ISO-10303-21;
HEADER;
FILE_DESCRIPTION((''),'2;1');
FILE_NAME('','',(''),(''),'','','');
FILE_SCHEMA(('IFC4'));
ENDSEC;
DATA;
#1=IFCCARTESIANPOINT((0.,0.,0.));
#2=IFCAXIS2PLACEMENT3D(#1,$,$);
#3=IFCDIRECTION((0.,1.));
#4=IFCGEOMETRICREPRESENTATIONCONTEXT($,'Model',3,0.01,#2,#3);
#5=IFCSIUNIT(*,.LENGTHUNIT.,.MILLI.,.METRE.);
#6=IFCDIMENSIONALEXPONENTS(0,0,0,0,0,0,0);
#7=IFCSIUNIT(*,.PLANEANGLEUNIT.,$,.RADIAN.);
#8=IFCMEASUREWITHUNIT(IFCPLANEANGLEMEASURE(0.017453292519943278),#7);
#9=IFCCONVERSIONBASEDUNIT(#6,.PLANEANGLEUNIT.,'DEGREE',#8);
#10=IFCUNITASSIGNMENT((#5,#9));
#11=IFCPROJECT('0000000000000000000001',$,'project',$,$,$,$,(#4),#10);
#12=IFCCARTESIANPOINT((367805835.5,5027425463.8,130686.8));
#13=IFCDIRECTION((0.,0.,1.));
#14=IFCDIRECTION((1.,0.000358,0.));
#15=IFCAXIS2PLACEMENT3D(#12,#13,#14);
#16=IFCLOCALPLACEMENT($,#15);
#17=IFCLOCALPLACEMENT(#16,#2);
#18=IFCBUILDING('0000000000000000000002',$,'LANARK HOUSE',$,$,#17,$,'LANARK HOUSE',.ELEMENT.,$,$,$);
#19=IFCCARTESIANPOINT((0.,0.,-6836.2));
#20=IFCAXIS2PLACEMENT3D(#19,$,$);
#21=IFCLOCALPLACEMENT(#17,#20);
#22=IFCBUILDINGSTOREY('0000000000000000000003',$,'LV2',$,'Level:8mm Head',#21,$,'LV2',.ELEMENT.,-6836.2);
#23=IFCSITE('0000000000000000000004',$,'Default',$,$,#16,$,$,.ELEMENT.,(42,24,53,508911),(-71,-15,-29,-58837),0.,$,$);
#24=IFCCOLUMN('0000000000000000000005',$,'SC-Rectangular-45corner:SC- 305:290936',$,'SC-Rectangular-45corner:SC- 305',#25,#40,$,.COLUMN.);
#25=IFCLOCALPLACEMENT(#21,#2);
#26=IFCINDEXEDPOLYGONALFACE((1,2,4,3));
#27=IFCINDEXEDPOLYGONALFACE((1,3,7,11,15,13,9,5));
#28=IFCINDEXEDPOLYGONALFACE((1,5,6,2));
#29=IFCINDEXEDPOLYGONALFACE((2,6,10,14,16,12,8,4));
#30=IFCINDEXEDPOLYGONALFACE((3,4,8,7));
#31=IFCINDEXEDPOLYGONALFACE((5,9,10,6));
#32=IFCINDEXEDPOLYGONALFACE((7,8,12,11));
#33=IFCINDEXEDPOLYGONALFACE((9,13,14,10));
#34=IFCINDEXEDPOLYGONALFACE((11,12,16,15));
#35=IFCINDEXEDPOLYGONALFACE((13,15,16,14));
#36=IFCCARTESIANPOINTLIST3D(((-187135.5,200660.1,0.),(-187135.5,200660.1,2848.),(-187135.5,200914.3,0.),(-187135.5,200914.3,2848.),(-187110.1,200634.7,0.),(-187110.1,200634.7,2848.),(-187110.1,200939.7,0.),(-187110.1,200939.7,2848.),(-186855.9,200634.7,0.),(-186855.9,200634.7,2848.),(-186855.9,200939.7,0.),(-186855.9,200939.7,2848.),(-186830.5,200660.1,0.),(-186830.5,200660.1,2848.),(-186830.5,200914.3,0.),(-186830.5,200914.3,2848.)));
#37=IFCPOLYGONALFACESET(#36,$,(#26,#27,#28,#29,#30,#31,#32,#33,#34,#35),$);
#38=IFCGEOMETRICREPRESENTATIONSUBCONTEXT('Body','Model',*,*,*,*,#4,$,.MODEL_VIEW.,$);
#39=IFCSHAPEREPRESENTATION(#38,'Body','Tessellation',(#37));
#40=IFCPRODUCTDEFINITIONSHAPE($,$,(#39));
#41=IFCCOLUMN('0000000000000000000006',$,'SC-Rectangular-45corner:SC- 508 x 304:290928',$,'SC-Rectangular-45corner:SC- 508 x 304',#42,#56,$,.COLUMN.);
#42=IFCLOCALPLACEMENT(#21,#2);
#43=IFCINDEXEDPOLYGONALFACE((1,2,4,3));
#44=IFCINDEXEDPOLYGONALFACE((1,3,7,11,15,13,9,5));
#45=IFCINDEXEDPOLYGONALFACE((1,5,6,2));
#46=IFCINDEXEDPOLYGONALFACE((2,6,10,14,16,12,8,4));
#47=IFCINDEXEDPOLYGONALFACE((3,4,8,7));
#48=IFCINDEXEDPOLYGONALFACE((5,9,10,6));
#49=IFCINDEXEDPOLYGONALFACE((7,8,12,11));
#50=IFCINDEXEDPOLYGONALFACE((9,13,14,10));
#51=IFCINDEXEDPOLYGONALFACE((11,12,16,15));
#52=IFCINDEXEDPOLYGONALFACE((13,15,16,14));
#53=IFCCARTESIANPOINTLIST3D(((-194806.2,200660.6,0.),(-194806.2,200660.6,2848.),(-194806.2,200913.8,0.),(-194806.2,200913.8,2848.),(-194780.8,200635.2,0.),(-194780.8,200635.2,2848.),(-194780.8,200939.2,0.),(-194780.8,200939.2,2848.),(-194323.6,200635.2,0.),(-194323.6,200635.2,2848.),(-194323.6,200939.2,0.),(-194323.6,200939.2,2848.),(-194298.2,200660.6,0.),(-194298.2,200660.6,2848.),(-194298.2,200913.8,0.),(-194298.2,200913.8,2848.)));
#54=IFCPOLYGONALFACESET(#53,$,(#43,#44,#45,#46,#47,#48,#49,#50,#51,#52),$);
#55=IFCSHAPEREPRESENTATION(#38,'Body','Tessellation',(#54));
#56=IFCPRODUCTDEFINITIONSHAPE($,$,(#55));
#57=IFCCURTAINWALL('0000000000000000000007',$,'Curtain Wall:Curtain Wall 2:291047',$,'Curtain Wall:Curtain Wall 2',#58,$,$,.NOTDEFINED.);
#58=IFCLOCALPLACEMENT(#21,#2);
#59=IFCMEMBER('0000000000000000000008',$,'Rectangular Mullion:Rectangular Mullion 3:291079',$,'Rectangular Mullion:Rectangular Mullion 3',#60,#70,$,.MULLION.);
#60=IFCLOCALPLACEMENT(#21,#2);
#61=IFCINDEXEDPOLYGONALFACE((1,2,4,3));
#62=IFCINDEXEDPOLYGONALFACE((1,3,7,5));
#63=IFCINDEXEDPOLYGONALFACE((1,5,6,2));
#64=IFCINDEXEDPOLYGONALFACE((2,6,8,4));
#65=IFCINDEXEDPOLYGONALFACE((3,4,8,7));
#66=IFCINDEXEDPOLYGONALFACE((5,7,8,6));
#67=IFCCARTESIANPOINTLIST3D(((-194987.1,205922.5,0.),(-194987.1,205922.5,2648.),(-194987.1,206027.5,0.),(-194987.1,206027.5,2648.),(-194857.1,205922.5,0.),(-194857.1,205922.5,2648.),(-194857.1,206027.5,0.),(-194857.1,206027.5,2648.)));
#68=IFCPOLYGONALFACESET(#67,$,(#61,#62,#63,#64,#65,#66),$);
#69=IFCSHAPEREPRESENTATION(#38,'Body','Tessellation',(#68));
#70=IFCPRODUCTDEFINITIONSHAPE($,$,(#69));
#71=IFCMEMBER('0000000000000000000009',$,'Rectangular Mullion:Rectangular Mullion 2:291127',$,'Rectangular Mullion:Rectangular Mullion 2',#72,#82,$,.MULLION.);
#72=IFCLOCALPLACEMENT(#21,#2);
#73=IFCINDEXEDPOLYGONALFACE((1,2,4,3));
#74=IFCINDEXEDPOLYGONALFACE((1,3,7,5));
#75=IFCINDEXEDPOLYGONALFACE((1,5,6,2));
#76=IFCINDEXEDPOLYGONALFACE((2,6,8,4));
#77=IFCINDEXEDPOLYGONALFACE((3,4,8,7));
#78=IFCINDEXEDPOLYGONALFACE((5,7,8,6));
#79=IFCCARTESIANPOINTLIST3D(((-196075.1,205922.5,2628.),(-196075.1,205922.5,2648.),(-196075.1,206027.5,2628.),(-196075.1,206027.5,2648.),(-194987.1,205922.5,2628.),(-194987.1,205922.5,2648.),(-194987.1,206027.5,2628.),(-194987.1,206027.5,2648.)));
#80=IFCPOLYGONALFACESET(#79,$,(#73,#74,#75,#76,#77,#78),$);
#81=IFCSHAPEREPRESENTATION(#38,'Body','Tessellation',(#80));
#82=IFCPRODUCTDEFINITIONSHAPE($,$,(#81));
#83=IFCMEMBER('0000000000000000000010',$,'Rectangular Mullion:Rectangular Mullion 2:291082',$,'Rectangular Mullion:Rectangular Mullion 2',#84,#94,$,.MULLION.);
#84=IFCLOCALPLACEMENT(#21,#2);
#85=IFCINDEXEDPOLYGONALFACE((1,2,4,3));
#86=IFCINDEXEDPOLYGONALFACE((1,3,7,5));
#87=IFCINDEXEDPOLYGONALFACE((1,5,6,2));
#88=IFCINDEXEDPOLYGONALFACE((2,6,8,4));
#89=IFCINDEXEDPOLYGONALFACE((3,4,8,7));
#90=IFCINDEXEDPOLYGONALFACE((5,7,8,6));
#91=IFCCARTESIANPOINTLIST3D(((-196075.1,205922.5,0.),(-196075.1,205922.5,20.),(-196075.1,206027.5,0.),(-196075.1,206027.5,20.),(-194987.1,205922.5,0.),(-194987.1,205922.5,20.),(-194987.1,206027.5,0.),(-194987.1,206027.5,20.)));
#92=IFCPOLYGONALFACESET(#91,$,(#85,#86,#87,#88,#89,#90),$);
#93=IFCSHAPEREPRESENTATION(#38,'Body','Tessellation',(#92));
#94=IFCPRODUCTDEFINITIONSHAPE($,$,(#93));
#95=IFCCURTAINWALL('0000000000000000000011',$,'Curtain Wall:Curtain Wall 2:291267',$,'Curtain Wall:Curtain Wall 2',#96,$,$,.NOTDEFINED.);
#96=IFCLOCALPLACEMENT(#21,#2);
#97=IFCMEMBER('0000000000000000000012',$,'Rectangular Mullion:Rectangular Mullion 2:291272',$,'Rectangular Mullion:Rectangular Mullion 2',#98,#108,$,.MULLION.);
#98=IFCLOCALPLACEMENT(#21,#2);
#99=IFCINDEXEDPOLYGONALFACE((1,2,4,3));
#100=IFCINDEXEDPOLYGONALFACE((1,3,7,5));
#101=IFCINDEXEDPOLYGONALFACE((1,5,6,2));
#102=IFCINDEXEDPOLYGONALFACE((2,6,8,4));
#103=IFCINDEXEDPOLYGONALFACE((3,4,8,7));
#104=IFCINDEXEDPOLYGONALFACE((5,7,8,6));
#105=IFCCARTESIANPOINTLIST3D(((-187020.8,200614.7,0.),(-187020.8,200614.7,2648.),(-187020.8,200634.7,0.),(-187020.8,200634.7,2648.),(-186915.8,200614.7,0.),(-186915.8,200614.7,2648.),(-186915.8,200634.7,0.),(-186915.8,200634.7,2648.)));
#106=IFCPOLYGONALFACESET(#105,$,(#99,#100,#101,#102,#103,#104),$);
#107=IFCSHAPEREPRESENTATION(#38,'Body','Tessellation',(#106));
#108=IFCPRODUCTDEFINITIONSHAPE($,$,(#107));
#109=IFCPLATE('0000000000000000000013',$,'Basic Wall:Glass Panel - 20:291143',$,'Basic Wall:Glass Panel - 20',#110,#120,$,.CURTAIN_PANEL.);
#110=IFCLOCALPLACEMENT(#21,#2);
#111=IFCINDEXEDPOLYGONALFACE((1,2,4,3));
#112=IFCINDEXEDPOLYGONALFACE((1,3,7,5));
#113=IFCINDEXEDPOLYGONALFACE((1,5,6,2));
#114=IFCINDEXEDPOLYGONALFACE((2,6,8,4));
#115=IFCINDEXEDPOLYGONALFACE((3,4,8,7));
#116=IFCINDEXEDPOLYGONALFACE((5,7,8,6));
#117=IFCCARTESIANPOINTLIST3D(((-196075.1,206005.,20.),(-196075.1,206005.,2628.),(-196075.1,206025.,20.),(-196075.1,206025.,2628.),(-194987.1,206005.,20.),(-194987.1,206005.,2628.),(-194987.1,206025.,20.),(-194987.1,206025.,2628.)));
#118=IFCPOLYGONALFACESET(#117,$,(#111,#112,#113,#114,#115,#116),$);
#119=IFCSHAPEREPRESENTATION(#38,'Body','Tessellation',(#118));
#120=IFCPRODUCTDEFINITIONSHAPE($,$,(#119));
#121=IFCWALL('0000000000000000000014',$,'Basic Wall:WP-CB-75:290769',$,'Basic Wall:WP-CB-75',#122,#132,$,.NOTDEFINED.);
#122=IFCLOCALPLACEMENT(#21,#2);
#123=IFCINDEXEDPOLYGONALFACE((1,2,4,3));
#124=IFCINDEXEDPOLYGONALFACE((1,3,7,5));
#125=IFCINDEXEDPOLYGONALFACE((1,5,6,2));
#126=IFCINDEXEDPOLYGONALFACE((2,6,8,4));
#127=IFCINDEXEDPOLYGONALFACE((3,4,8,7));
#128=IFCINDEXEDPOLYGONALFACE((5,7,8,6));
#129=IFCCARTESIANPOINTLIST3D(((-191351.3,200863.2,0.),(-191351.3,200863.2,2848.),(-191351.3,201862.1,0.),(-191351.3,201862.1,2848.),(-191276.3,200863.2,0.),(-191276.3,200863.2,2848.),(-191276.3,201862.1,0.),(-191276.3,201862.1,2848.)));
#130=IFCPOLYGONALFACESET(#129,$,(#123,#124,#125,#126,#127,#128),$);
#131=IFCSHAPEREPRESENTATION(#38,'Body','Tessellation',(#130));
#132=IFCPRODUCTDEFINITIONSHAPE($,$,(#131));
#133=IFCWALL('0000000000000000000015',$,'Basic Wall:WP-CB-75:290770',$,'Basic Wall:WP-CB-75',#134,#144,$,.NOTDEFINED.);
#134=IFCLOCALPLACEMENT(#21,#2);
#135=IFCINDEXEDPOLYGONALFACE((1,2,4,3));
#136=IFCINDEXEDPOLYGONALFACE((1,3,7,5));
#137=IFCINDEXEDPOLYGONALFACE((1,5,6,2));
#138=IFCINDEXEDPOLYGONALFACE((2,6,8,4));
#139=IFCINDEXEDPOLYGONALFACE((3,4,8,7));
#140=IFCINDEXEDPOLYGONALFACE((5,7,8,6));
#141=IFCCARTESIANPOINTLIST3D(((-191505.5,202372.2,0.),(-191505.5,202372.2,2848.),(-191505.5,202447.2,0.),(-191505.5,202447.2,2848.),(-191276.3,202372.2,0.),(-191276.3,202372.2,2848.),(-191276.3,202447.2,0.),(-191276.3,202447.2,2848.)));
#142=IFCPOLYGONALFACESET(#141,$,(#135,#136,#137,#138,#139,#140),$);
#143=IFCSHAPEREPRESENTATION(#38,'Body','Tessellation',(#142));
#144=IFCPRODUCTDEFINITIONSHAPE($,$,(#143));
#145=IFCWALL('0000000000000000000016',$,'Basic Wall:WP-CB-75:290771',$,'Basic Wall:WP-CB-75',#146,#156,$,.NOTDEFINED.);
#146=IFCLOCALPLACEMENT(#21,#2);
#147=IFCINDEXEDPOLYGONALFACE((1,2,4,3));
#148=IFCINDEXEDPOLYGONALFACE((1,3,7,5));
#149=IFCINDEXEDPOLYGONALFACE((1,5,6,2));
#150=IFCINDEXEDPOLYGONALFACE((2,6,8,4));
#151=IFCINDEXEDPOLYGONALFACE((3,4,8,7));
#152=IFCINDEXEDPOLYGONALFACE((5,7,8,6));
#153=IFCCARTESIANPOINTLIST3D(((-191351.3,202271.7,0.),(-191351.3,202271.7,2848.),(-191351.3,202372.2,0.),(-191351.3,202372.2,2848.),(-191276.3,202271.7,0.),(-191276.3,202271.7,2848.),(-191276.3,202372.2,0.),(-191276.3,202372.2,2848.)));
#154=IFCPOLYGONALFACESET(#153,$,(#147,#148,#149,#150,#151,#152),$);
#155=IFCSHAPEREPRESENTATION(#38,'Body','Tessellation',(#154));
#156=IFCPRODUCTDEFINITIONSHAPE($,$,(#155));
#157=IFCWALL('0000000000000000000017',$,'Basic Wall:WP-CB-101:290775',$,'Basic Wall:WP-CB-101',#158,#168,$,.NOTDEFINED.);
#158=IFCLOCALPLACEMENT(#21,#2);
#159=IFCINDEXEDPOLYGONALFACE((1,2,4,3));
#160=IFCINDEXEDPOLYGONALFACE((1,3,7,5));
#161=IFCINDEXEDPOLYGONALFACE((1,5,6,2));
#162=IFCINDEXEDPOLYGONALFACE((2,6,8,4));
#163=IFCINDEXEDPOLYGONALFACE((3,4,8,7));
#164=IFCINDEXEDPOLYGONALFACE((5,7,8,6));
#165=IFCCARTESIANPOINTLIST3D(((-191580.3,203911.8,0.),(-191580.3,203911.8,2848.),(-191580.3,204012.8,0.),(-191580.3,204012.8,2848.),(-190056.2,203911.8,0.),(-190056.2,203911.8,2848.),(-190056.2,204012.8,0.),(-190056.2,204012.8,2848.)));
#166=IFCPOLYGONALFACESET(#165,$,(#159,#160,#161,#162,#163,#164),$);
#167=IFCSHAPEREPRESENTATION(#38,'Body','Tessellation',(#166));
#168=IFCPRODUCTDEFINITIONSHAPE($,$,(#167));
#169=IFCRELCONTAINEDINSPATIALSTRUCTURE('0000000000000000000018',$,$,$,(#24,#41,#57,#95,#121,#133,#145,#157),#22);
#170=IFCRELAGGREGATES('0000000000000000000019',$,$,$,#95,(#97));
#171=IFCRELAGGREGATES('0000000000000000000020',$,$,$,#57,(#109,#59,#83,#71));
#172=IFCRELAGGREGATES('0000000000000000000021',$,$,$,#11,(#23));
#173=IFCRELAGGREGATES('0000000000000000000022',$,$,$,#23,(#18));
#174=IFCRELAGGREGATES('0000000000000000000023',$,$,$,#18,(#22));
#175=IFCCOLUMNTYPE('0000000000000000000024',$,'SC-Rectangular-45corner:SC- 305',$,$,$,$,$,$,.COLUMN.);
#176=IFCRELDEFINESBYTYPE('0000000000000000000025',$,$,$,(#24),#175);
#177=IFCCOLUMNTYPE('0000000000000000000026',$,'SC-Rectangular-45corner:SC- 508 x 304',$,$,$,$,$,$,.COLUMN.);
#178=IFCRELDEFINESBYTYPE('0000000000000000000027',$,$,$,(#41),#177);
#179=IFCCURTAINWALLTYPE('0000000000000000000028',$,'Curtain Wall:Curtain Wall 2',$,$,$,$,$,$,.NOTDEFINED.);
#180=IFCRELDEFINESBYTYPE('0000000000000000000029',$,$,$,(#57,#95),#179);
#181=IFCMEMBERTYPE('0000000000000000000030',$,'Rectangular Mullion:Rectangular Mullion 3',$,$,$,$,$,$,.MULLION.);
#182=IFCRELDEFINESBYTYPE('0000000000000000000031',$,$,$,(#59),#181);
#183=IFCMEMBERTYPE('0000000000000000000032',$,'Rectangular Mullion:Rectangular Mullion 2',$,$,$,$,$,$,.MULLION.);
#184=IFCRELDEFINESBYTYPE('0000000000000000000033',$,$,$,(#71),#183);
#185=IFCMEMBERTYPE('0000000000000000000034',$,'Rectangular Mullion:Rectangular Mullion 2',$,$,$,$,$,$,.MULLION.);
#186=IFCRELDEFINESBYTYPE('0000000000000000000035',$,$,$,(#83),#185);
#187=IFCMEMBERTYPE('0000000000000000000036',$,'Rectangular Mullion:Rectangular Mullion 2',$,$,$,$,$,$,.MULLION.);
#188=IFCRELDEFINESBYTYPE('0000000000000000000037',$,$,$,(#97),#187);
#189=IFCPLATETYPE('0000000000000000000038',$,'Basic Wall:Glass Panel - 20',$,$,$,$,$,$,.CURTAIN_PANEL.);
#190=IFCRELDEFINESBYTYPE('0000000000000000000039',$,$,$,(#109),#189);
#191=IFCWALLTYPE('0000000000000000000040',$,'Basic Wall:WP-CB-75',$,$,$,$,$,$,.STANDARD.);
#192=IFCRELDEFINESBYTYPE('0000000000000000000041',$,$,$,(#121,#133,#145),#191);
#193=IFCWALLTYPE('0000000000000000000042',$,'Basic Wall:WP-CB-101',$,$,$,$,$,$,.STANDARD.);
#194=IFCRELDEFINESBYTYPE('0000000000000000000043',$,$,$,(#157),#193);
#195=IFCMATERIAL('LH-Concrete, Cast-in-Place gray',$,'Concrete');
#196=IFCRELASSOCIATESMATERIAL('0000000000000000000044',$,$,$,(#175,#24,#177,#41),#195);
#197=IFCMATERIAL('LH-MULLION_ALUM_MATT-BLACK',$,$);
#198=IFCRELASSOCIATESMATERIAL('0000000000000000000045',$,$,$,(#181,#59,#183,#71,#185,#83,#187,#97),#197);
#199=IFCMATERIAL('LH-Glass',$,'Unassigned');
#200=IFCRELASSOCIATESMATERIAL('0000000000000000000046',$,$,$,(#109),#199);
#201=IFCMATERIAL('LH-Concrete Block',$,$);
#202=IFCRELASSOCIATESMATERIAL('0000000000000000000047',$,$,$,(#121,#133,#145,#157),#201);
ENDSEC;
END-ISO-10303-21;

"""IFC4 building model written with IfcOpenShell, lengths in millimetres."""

from ifc_helpers import new_model, entity, si_unit, converted_unit, direction, frame, origin, place, context, subcontext, project, spatial, indexed_curve, outline, extrude, source, transform, mapped, material, type_object, type_shapes, element, aggregate, save


model = new_model("IFC4")

# Units and contexts
model_context = context("Model", 3, precision=0.01, world=origin(), true_north=direction((0.0, 1.0)))
body_context = subcontext(model_context, "Body", "Model", "MODEL_VIEW")
ifc_project = project(units=[si_unit("LENGTHUNIT", "METRE", prefix="MILLI"), converted_unit("PLANEANGLEUNIT", "DEGREE", entity("IfcPlaneAngleMeasure", 0.017453292519943278), si_unit("PLANEANGLEUNIT", "RADIAN"), dimensions=[0, 0, 0, 0, 0, 0, 0])], contexts=[model_context])

# Site, building, storey
site_placement = place(None, frame((367805835.5, 5027425463.8, 130686.8), z_axis=(0.0, 0.0, 1.0), x_axis=(1.0, 0.000358, 0.0)))
site = spatial("IfcSite", under=ifc_project, at=site_placement, Name="Default", CompositionType="ELEMENT", RefLatitude=(42, 24, 53, 508911), RefLongitude=(-71, -15, -29, -58837), RefElevation=0.0)
building_placement = place(site_placement, origin())
building = spatial("IfcBuilding", under=site, at=building_placement, Name="LANARK HOUSE", LongName="LANARK HOUSE", CompositionType="ELEMENT")
storey_placement = place(building_placement, frame((0.0, 0.0, -6836.2)))
storey = spatial("IfcBuildingStorey", under=building, at=storey_placement, Name="LV2", ObjectType="Level:8mm Head", LongName="LV2", CompositionType="ELEMENT", Elevation=-6836.2)

# Columns
ifc_material_1 = material(Name="LH-Concrete, Cast-in-Place gray", Category="Concrete")
column_type_1 = type_object("IfcColumnType", Name="SC-Rectangular-45corner:SC- 305", PredefinedType="COLUMN", material=ifc_material_1)
shared_shape_1 = source(origin(), body_context, "Body", "SweptSolid", [
    extrude(outline(indexed_curve([(-127.1, -152.5), (127.1, -152.5), (152.5, -127.1), (152.5, 127.1), (127.1, 152.5), (-127.1, 152.5), (-152.5, 127.1), (-152.5, -127.1), (-127.1, -152.5)], self_intersect=False)), frame((0.0, 0.0, -6836.2), z_axis=(0.0, 0.0, 1.0), x_axis=(-1.0, 0.0, 0.0)), (0.0, 0.0, 1.0), 2848.0),
])
type_shapes(column_type_1, [shared_shape_1])
column_1_placement = place(storey_placement, frame((-186983.0, 200787.2, 6836.2)))
element("IfcColumn", 1, at=column_1_placement, inside=storey, type_object=column_type_1, material=ifc_material_1, Name="SC-Rectangular-45corner:SC- 305:290936", ObjectType="SC-Rectangular-45corner:SC- 305", PredefinedType="COLUMN", context=body_context, shape_type="MappedRepresentation", body=[
    mapped(shared_shape_1, transform((0.0, 0.0, 0.0), scale=1.0)),
])
column_type_2 = type_object("IfcColumnType", Name="SC-Rectangular-45corner:SC- 508 x 304", PredefinedType="COLUMN", material=ifc_material_1)
shared_shape_2 = source(origin(), body_context, "Body", "SweptSolid", [
    extrude(outline(indexed_curve([(-228.6, -152.0), (228.6, -152.0), (254.0, -126.6), (254.0, 126.6), (228.6, 152.0), (-228.6, 152.0), (-254.0, 126.6), (-254.0, -126.6), (-228.6, -152.0)], self_intersect=False)), frame((0.0, 0.0, -6836.2), z_axis=(0.0, 0.0, 1.0), x_axis=(-1.0, 0.0, 0.0)), (0.0, 0.0, 1.0), 2848.0),
])
type_shapes(column_type_2, [shared_shape_2])
column_2_placement = place(storey_placement, frame((-194552.2, 200787.2, 6836.2)))
element("IfcColumn", 2, at=column_2_placement, inside=storey, type_object=column_type_2, material=ifc_material_1, Name="SC-Rectangular-45corner:SC- 508 x 304:290928", ObjectType="SC-Rectangular-45corner:SC- 508 x 304", PredefinedType="COLUMN", context=body_context, shape_type="MappedRepresentation", body=[
    mapped(shared_shape_2, transform((0.0, 0.0, 0.0), scale=1.0)),
])

# Curtain wall, members
curtain_wall_type = type_object("IfcCurtainWallType", Name="Curtain Wall:Curtain Wall 2", PredefinedType="NOTDEFINED")
curtain_wall_1_placement = place(storey_placement, frame((0.0, 0.0, 6836.2)))
curtain_wall_1 = element("IfcCurtainWall", 3, at=curtain_wall_1_placement, inside=storey, type_object=curtain_wall_type, Name="Curtain Wall:Curtain Wall 2:291047", ObjectType="Curtain Wall:Curtain Wall 2", PredefinedType="NOTDEFINED")
ifc_material_2 = material(Name="LH-MULLION_ALUM_MATT-BLACK")
member_type_1 = type_object("IfcMemberType", Name="Rectangular Mullion:Rectangular Mullion 3", PredefinedType="MULLION", material=ifc_material_2)
shared_shape_3 = source(origin(), body_context, "Body", "SweptSolid", [
    extrude(outline(indexed_curve([(-65.0, -52.5), (65.0, -52.5), (65.0, 52.5), (-65.0, 52.5), (-65.0, -52.5)], self_intersect=False)), frame((-65.0, -40.0, -2648.0), z_axis=(0.0, 0.0, 1.0), x_axis=(-1.0, 0.0, 0.0)), (0.0, 0.0, 1.0), 2648.0),
])
type_shapes(member_type_1, [shared_shape_3])
member_1_placement = place(curtain_wall_1_placement, frame((-194857.1, 206015.0, -4188.2)))
member_1 = element("IfcMember", 4, at=member_1_placement, type_object=member_type_1, material=ifc_material_2, Name="Rectangular Mullion:Rectangular Mullion 3:291079", ObjectType="Rectangular Mullion:Rectangular Mullion 3", PredefinedType="MULLION", context=body_context, shape_type="MappedRepresentation", body=[
    mapped(shared_shape_3, transform((0.0, 0.0, 0.0), scale=1.0)),
])
member_type_2 = type_object("IfcMemberType", Name="Rectangular Mullion:Rectangular Mullion 2", PredefinedType="MULLION", material=ifc_material_2)
shared_shape_4 = source(origin(), body_context, "Body", "SweptSolid", [
    extrude(outline(indexed_curve([(-10.0, -52.5), (10.0, -52.5), (10.0, 52.5), (-10.0, 52.5), (-10.0, -52.5)], self_intersect=False)), frame((-10.0, -40.0, -1088.0), z_axis=(0.0, 0.0, 1.0), x_axis=(-1.0, 0.0, 0.0)), (0.0, 0.0, 1.0), 1088.0),
])
type_shapes(member_type_2, [shared_shape_4])
member_2_placement = place(curtain_wall_1_placement, frame((-196075.1, 206015.0, -4188.2), z_axis=(-1.0, 0.0, 0.0), x_axis=(0.0, 0.0, 1.0)))
member_2 = element("IfcMember", 5, at=member_2_placement, type_object=member_type_2, material=ifc_material_2, Name="Rectangular Mullion:Rectangular Mullion 2:291127", ObjectType="Rectangular Mullion:Rectangular Mullion 2", PredefinedType="MULLION", context=body_context, shape_type="MappedRepresentation", body=[
    mapped(shared_shape_4, transform((0.0, 0.0, 0.0), scale=1.0)),
])
member_type_3 = type_object("IfcMemberType", Name="Rectangular Mullion:Rectangular Mullion 2", PredefinedType="MULLION", material=ifc_material_2)
shared_shape_5 = source(origin(), body_context, "Body", "SweptSolid", [
    extrude(outline(indexed_curve([(-10.0, -52.5), (10.0, -52.5), (10.0, 52.5), (-10.0, 52.5), (-10.0, -52.5)], self_intersect=False)), frame((-10.0, -40.0, -1088.0), z_axis=(0.0, 0.0, 1.0), x_axis=(-1.0, 0.0, 0.0)), (0.0, 0.0, 1.0), 1088.0),
])
type_shapes(member_type_3, [shared_shape_5])
member_3_placement = place(curtain_wall_1_placement, frame((-194987.1, 206015.0, -6836.2), z_axis=(1.0, 0.0, 0.0), x_axis=(0.0, 0.0, -1.0)))
member_3 = element("IfcMember", 6, at=member_3_placement, type_object=member_type_3, material=ifc_material_2, Name="Rectangular Mullion:Rectangular Mullion 2:291082", ObjectType="Rectangular Mullion:Rectangular Mullion 2", PredefinedType="MULLION", context=body_context, shape_type="MappedRepresentation", body=[
    mapped(shared_shape_5, transform((0.0, 0.0, 0.0), scale=1.0)),
])

# Curtain wall, member
curtain_wall_2_placement = place(storey_placement, frame((0.0, 0.0, 6836.2)))
curtain_wall_2 = element("IfcCurtainWall", 7, at=curtain_wall_2_placement, inside=storey, type_object=curtain_wall_type, Name="Curtain Wall:Curtain Wall 2:291267", ObjectType="Curtain Wall:Curtain Wall 2", PredefinedType="NOTDEFINED")
member_type_4 = type_object("IfcMemberType", Name="Rectangular Mullion:Rectangular Mullion 2", PredefinedType="MULLION", material=ifc_material_2)
shared_shape_6 = source(origin(), body_context, "Body", "SweptSolid", [
    extrude(outline(indexed_curve([(-10.0, -52.5), (10.0, -52.5), (10.0, 52.5), (-10.0, 52.5), (-10.0, -52.5)], self_intersect=False)), frame((-10.0, -40.0, -2648.0), z_axis=(0.0, 0.0, 1.0), x_axis=(-1.0, 0.0, 0.0)), (0.0, 0.0, 1.0), 2648.0),
])
type_shapes(member_type_4, [shared_shape_6])
member_4_placement = place(curtain_wall_2_placement, frame((-187008.3, 200634.7, -4188.2), z_axis=(0.0, 0.0, 1.0), x_axis=(0.0, 1.0, 0.0)))
member_4 = element("IfcMember", 8, at=member_4_placement, type_object=member_type_4, material=ifc_material_2, Name="Rectangular Mullion:Rectangular Mullion 2:291272", ObjectType="Rectangular Mullion:Rectangular Mullion 2", PredefinedType="MULLION", context=body_context, shape_type="MappedRepresentation", body=[
    mapped(shared_shape_6, transform((0.0, 0.0, 0.0), scale=1.0)),
])
aggregate(curtain_wall_2, [member_4])

# Plate
ifc_material_3 = material(Name="LH-Glass", Category="Unassigned")
plate_type = type_object("IfcPlateType", Name="Basic Wall:Glass Panel - 20", PredefinedType="CURTAIN_PANEL")
plate_placement = place(storey_placement, frame((-194987.1, 206015.0, 20.0), z_axis=(0.0, 0.0, 1.0), x_axis=(-1.0, 0.0, 0.0)))
plate = element("IfcPlate", 9, at=plate_placement, type_object=plate_type, material=ifc_material_3, Name="Basic Wall:Glass Panel - 20:291143", ObjectType="Basic Wall:Glass Panel - 20", PredefinedType="CURTAIN_PANEL", context=body_context, shape_type="SweptSolid", body=[
    extrude(outline(indexed_curve([(-10.0, -544.0), (10.0, -544.0), (10.0, 544.0), (-10.0, 544.0), (-10.0, -544.0)], self_intersect=False)), frame((544.0, 0.0, 0.0), z_axis=(0.0, 0.0, 1.0), x_axis=(0.0, 1.0, 0.0)), (0.0, 0.0, 1.0), 2608.0),
])
aggregate(curtain_wall_1, [plate, member_1, member_3, member_2])

# Walls
ifc_material_4 = material(Name="LH-Concrete Block")
wall_type_1 = type_object("IfcWallType", Name="Basic Wall:WP-CB-75", PredefinedType="STANDARD")
wall_1_placement = place(storey_placement, frame((-191313.8, 200863.2, 0.0), z_axis=(0.0, 0.0, 1.0), x_axis=(0.0, 1.0, 0.0)))
element("IfcWall", 10, at=wall_1_placement, inside=storey, type_object=wall_type_1, material=ifc_material_4, Name="Basic Wall:WP-CB-75:290769", ObjectType="Basic Wall:WP-CB-75", PredefinedType="NOTDEFINED", context=body_context, shape_type="SweptSolid", body=[
    extrude(outline(indexed_curve([(998.9, 37.5), (0.0, 37.5), (0.0, -37.5), (998.9, -37.5), (998.9, 37.5)], self_intersect=False)), origin(), (0.0, 0.0, 1.0), 2848.0),
])
wall_2_placement = place(storey_placement, frame((-191505.5, 202409.7, 0.0)))
element("IfcWall", 11, at=wall_2_placement, inside=storey, type_object=wall_type_1, material=ifc_material_4, Name="Basic Wall:WP-CB-75:290770", ObjectType="Basic Wall:WP-CB-75", PredefinedType="NOTDEFINED", context=body_context, shape_type="SweptSolid", body=[
    extrude(outline(indexed_curve([(229.2, 37.5), (0.0, 37.5), (0.0, -37.5), (229.2, -37.5), (229.2, 37.5)], self_intersect=False)), origin(), (0.0, 0.0, 1.0), 2848.0),
])
wall_3_placement = place(storey_placement, frame((-191313.8, 202372.2, 0.0), z_axis=(0.0, 0.0, 1.0), x_axis=(0.0, -1.0, 0.0)))
element("IfcWall", 12, at=wall_3_placement, inside=storey, type_object=wall_type_1, material=ifc_material_4, Name="Basic Wall:WP-CB-75:290771", ObjectType="Basic Wall:WP-CB-75", PredefinedType="NOTDEFINED", context=body_context, shape_type="SweptSolid", body=[
    extrude(outline(indexed_curve([(100.5, 37.5), (0.0, 37.5), (0.0, -37.5), (100.5, -37.5), (100.5, 37.5)], self_intersect=False)), origin(), (0.0, 0.0, 1.0), 2848.0),
])
wall_type_2 = type_object("IfcWallType", Name="Basic Wall:WP-CB-101", PredefinedType="STANDARD")
wall_4_placement = place(storey_placement, frame((-190056.2, 203962.3, 0.0), z_axis=(0.0, 0.0, 1.0), x_axis=(-1.0, 0.0, 0.0)))
element("IfcWall", 13, at=wall_4_placement, inside=storey, type_object=wall_type_2, material=ifc_material_4, Name="Basic Wall:WP-CB-101:290775", ObjectType="Basic Wall:WP-CB-101", PredefinedType="NOTDEFINED", context=body_context, shape_type="SweptSolid", body=[
    extrude(outline(indexed_curve([(1524.1, 50.5), (0.0, 50.5), (0.0, -50.5), (1524.1, -50.5), (1524.1, 50.5)], self_intersect=False)), origin(), (0.0, 0.0, 1.0), 2848.0),
])

save(model, "model.ifc")
